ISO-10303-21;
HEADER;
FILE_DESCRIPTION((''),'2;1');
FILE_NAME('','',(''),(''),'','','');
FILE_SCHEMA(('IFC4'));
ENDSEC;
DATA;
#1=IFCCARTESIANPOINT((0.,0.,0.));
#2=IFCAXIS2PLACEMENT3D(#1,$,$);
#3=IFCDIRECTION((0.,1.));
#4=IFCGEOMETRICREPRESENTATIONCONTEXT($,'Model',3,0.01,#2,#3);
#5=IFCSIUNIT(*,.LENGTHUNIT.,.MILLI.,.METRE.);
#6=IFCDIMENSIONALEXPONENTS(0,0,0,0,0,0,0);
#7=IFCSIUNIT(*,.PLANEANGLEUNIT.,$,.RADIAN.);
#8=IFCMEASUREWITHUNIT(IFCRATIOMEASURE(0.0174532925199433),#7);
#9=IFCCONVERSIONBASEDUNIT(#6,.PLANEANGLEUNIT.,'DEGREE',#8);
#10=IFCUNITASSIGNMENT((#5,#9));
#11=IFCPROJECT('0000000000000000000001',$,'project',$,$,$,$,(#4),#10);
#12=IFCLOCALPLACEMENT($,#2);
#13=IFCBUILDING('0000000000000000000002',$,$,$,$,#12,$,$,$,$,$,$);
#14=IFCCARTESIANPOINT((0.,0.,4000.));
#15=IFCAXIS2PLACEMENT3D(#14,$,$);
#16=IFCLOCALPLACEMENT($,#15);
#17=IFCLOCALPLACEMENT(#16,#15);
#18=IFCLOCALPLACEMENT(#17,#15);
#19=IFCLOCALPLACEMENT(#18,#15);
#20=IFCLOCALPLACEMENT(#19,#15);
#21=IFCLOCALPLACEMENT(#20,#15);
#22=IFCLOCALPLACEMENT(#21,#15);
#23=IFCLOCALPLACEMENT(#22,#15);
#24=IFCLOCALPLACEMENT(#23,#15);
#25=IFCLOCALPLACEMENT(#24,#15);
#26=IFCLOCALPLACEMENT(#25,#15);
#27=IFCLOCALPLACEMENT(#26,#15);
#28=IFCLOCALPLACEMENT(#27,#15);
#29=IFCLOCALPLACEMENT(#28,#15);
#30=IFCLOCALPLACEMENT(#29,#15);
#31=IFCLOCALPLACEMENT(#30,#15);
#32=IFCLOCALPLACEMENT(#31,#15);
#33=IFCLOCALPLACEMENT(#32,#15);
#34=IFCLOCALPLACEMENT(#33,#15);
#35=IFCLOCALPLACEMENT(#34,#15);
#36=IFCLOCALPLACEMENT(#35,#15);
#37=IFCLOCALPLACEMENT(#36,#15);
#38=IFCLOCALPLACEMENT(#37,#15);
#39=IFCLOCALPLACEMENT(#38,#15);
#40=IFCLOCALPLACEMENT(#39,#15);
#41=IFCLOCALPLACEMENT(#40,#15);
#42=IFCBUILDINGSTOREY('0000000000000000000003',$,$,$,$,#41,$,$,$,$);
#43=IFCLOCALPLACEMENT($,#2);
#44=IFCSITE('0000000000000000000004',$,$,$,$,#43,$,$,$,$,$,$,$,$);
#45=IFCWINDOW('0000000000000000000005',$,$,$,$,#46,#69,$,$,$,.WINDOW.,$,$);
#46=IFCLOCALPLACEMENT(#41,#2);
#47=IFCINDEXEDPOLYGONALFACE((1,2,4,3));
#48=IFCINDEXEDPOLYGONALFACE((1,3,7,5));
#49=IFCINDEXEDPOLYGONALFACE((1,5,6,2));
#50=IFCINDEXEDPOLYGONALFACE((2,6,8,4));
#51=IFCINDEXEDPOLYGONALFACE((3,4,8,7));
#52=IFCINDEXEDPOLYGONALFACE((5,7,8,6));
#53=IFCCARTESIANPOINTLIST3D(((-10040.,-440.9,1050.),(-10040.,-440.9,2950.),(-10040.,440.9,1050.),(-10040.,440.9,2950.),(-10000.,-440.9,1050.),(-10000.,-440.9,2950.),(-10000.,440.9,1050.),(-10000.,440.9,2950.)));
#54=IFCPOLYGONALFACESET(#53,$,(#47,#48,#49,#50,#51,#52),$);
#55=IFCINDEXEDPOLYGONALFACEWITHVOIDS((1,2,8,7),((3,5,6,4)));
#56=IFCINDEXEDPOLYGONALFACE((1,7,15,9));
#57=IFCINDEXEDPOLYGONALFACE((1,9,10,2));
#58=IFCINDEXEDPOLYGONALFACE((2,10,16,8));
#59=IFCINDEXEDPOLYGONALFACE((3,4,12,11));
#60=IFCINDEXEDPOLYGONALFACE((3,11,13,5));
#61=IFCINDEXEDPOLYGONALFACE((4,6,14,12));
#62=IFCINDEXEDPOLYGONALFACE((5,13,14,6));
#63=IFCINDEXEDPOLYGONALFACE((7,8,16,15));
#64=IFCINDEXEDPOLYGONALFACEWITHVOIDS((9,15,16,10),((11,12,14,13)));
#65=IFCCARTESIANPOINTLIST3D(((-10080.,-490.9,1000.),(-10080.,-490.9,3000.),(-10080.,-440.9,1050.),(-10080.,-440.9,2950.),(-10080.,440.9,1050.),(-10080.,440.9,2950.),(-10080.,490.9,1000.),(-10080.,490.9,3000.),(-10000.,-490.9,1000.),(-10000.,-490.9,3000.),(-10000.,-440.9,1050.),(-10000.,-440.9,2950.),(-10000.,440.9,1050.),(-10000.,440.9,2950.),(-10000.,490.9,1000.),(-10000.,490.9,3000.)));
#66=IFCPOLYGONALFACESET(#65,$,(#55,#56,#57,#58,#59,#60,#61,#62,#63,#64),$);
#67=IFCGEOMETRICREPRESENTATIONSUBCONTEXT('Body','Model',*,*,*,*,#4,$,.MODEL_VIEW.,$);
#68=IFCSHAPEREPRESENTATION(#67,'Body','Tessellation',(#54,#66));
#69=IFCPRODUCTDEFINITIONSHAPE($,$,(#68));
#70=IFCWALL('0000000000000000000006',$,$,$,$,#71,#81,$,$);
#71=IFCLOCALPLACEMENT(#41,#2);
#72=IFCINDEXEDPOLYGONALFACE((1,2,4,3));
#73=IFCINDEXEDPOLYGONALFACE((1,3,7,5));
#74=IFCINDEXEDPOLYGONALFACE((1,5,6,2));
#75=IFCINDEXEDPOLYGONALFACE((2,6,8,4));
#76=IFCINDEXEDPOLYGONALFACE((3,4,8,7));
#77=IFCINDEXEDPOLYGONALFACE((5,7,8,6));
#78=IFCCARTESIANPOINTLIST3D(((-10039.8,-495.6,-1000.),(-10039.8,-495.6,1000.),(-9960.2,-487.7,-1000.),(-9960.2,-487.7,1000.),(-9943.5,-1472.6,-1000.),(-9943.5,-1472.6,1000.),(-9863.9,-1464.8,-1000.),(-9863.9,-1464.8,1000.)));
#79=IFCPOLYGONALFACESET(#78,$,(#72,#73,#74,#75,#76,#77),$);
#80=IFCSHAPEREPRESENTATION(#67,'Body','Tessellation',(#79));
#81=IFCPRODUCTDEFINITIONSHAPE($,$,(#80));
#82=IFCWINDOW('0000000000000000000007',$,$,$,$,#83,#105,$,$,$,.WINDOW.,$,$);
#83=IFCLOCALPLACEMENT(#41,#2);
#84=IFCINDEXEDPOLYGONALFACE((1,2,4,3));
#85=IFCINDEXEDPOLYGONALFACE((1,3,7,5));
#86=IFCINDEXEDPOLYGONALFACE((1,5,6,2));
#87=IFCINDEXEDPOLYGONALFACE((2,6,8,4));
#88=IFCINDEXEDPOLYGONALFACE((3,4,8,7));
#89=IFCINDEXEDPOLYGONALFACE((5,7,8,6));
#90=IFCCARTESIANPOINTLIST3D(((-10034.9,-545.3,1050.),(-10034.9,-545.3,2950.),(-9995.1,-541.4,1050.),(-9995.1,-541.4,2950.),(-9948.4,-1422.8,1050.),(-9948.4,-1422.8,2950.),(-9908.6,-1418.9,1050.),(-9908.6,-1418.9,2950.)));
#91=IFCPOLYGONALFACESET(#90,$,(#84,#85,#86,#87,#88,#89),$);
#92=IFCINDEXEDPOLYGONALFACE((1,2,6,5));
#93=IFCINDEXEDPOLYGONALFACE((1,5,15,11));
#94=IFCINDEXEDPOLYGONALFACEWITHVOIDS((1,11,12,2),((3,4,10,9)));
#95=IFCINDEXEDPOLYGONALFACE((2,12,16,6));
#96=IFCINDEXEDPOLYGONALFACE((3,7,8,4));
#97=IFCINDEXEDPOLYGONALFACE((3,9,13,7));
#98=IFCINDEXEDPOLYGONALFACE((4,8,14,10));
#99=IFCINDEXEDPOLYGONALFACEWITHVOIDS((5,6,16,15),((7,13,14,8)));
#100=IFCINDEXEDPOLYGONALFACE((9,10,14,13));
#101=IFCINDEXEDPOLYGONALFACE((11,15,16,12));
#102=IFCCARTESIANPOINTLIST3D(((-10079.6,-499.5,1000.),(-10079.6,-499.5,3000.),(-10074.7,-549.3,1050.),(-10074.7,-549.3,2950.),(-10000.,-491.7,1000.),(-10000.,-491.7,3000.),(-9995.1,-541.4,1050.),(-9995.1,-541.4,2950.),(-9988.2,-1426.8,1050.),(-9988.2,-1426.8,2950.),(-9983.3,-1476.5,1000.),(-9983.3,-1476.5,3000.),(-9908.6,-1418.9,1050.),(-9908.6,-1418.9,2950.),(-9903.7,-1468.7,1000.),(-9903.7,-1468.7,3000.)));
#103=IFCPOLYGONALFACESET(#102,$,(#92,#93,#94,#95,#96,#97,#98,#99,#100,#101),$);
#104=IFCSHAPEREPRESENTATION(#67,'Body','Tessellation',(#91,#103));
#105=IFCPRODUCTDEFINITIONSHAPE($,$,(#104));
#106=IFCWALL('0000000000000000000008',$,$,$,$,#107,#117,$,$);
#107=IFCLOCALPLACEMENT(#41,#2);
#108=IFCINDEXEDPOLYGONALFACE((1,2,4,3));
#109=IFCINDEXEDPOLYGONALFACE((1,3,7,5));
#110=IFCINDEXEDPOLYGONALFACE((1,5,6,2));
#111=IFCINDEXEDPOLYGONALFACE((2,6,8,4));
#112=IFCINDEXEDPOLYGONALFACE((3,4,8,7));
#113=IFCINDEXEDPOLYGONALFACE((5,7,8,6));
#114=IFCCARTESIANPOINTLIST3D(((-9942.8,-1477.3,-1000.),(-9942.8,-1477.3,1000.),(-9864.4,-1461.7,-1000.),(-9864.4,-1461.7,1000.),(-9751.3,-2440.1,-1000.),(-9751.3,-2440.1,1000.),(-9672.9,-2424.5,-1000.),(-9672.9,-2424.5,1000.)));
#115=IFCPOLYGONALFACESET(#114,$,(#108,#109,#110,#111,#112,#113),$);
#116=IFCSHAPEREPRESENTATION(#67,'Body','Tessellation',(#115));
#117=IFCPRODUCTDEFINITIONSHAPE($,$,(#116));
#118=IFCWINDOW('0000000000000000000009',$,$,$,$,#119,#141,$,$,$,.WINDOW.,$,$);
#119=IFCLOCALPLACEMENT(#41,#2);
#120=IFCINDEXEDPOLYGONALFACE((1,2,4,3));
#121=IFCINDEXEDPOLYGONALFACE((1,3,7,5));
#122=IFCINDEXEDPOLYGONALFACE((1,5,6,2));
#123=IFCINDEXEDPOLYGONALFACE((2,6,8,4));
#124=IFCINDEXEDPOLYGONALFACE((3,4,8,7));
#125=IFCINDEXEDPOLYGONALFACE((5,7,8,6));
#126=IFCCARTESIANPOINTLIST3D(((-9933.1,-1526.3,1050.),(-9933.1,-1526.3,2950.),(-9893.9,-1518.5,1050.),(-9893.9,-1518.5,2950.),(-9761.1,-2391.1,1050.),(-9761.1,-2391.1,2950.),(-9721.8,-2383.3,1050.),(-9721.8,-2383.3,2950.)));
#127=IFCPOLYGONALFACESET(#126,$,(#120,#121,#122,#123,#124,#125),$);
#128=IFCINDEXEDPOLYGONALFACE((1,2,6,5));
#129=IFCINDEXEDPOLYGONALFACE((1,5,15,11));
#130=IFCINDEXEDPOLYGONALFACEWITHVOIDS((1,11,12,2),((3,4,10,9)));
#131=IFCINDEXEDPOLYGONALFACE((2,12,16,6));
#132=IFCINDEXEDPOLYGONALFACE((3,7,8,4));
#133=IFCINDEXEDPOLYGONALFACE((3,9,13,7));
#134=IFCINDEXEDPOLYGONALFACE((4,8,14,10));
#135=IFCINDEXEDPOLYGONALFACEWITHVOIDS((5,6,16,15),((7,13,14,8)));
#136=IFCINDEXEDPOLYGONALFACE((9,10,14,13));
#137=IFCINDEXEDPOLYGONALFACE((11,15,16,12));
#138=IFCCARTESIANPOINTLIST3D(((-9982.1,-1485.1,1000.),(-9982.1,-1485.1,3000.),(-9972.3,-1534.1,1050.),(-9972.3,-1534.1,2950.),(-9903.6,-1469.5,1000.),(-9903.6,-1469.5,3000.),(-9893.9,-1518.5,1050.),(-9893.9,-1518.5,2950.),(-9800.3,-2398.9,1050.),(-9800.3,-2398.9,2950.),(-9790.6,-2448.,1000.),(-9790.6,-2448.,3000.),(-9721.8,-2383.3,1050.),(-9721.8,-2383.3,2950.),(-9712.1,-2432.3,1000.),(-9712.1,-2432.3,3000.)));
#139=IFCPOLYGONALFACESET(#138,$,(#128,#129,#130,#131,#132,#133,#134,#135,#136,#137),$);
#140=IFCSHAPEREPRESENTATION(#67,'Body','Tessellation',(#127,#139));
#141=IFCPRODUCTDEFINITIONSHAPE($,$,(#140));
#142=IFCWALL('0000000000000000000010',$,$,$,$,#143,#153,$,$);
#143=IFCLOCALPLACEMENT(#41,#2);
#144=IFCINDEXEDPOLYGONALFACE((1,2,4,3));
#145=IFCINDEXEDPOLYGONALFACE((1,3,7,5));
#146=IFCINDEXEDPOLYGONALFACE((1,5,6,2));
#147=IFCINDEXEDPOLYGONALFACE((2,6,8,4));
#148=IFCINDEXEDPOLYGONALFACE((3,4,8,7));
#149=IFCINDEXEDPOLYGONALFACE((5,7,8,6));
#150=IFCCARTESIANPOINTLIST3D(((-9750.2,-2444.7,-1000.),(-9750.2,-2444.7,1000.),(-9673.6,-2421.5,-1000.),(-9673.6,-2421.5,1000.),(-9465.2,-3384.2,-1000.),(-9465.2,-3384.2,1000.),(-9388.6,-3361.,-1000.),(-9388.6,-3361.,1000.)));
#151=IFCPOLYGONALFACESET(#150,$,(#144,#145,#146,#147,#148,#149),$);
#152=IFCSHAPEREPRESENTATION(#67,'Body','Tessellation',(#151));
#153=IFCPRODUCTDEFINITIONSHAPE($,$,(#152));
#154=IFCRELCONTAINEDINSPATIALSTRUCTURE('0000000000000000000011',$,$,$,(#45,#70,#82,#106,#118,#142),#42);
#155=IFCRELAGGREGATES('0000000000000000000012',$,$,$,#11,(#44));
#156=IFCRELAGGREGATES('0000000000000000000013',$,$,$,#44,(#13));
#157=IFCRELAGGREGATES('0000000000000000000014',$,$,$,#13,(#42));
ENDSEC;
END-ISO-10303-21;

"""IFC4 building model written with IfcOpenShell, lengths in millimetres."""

from ifc_helpers import new_model, entity, si_unit, converted_unit, direction, frame, origin, origin_2d, place, context, subcontext, project, spatial, rectangle, extrude, element, save


model = new_model("IFC4")

# Units and contexts
model_context = context("Model", 3, precision=0.01, world=origin(), true_north=direction((0.0, 1.0)))
body_context = subcontext(model_context, "Body", "Model", "MODEL_VIEW")
ifc_project = project(units=[si_unit("LENGTHUNIT", "METRE", prefix="MILLI"), converted_unit("PLANEANGLEUNIT", "DEGREE", entity("IfcRatioMeasure", 0.0174532925199433), si_unit("PLANEANGLEUNIT", "RADIAN"), dimensions=[0, 0, 0, 0, 0, 0, 0])], contexts=[model_context])

# Site, building, storey
site_placement = place(None, origin())
site = spatial("IfcSite", under=ifc_project, at=site_placement)
building_placement = place(None, origin())
building = spatial("IfcBuilding", under=site, at=building_placement)
placement_1 = place(None, frame((0.0, 0.0, 4000.0)))
placement_2 = place(placement_1, frame((0.0, 0.0, 4000.0)))
placement_3 = place(placement_2, frame((0.0, 0.0, 4000.0)))
placement_4 = place(placement_3, frame((0.0, 0.0, 4000.0)))
placement_5 = place(placement_4, frame((0.0, 0.0, 4000.0)))
placement_6 = place(placement_5, frame((0.0, 0.0, 4000.0)))
placement_7 = place(placement_6, frame((0.0, 0.0, 4000.0)))
placement_8 = place(placement_7, frame((0.0, 0.0, 4000.0)))
placement_9 = place(placement_8, frame((0.0, 0.0, 4000.0)))
placement_10 = place(placement_9, frame((0.0, 0.0, 4000.0)))
placement_11 = place(placement_10, frame((0.0, 0.0, 4000.0)))
placement_12 = place(placement_11, frame((0.0, 0.0, 4000.0)))
placement_13 = place(placement_12, frame((0.0, 0.0, 4000.0)))
placement_14 = place(placement_13, frame((0.0, 0.0, 4000.0)))
placement_15 = place(placement_14, frame((0.0, 0.0, 4000.0)))
placement_16 = place(placement_15, frame((0.0, 0.0, 4000.0)))
placement_17 = place(placement_16, frame((0.0, 0.0, 4000.0)))
placement_18 = place(placement_17, frame((0.0, 0.0, 4000.0)))
placement_19 = place(placement_18, frame((0.0, 0.0, 4000.0)))
placement_20 = place(placement_19, frame((0.0, 0.0, 4000.0)))
placement_21 = place(placement_20, frame((0.0, 0.0, 4000.0)))
placement_22 = place(placement_21, frame((0.0, 0.0, 4000.0)))
placement_23 = place(placement_22, frame((0.0, 0.0, 4000.0)))
placement_24 = place(placement_23, frame((0.0, 0.0, 4000.0)))
placement_25 = place(placement_24, frame((0.0, 0.0, 4000.0)))
storey_placement = place(placement_25, frame((0.0, 0.0, 4000.0)))
storey = spatial("IfcBuildingStorey", under=building, at=storey_placement)

# Window
cartesian_point_1 = entity("IfcCartesianPoint", [-440.9, -950.0])
shared_polyline = entity("IfcPolyline", [cartesian_point_1, entity("IfcCartesianPoint", [-440.9, 950.0]), entity("IfcCartesianPoint", [-440.9, 950.0]), entity("IfcCartesianPoint", [440.9, 950.0]), entity("IfcCartesianPoint", [440.9, 950.0]), entity("IfcCartesianPoint", [440.9, -950.0]), entity("IfcCartesianPoint", [440.9, -950.0]), entity("IfcCartesianPoint", [-440.9, -950.0]), cartesian_point_1])
window_1_placement = place(storey_placement, frame((-10000.0, 0.0, 2000.0), z_axis=(0.0, 0.0, 1.0), x_axis=(0.000874, -10000.0, 0.0)))
cartesian_point_2 = entity("IfcCartesianPoint", [-490.9, -1000.0])
element("IfcWindow", 1, at=window_1_placement, inside=storey, PredefinedType="WINDOW", context=body_context, shape_type="SweptSolid", body=[
    entity("IfcExtrudedAreaSolid", entity("IfcArbitraryClosedProfileDef", "AREA", None, shared_polyline), entity("IfcAxis2Placement3D", entity("IfcCartesianPoint", [0.0, 0.0, 0.0]), entity("IfcDirection", [0.0, -1.0, 0.0]), entity("IfcDirection", [1.0, 0.0, 0.0])), entity("IfcDirection", [0.0, 0.0, 1.0]), 40.0),
    entity("IfcExtrudedAreaSolid", entity("IfcArbitraryProfileDefWithVoids", "AREA", None, entity("IfcPolyline", [cartesian_point_2, entity("IfcCartesianPoint", [-490.9, 1000.0]), entity("IfcCartesianPoint", [-490.9, 1000.0]), entity("IfcCartesianPoint", [490.9, 1000.0]), entity("IfcCartesianPoint", [490.9, 1000.0]), entity("IfcCartesianPoint", [490.9, -1000.0]), entity("IfcCartesianPoint", [490.9, -1000.0]), entity("IfcCartesianPoint", [-490.9, -1000.0]), cartesian_point_2]), [shared_polyline]), entity("IfcAxis2Placement3D", entity("IfcCartesianPoint", [0.0, 0.0, 0.0]), entity("IfcDirection", [0.0, -1.0, 0.0]), entity("IfcDirection", [1.0, 0.0, 0.0])), entity("IfcDirection", [0.0, 0.0, 1.0]), 80.0),
])

# Wall
wall_1_placement = place(storey_placement, frame((-9951.8, -980.2, -1000.0), z_axis=(0.0, 0.0, 1.0), x_axis=(980.170299, -9951.847376, 0.0)))
element("IfcWall", 2, at=wall_1_placement, inside=storey, context=body_context, shape_type="SweptSolid", body=[
    extrude(rectangle(XDim=981.7, YDim=80.0, at=origin_2d()), origin(), (0.0, 0.0, 1.0), 2000.0),
])

# Window
window_2_placement = place(storey_placement, frame((-9951.8, -980.2, 2000.0), z_axis=(0.0, 0.0, 1.0), x_axis=(980.170299, -9951.847376, 0.0)))
cartesian_point_3 = entity("IfcCartesianPoint", [-490.9, -1000.0])
element("IfcWindow", 3, at=window_2_placement, inside=storey, PredefinedType="WINDOW", context=body_context, shape_type="SweptSolid", body=[
    entity("IfcExtrudedAreaSolid", entity("IfcArbitraryClosedProfileDef", "AREA", None, shared_polyline), entity("IfcAxis2Placement3D", entity("IfcCartesianPoint", [0.0, 0.0, 0.0]), entity("IfcDirection", [0.0, -1.0, 0.0]), entity("IfcDirection", [1.0, 0.0, 0.0])), entity("IfcDirection", [0.0, 0.0, 1.0]), 40.0),
    entity("IfcExtrudedAreaSolid", entity("IfcArbitraryProfileDefWithVoids", "AREA", None, entity("IfcPolyline", [cartesian_point_3, entity("IfcCartesianPoint", [-490.9, 1000.0]), entity("IfcCartesianPoint", [-490.9, 1000.0]), entity("IfcCartesianPoint", [490.9, 1000.0]), entity("IfcCartesianPoint", [490.9, 1000.0]), entity("IfcCartesianPoint", [490.9, -1000.0]), entity("IfcCartesianPoint", [490.9, -1000.0]), entity("IfcCartesianPoint", [-490.9, -1000.0]), cartesian_point_3]), [shared_polyline]), entity("IfcAxis2Placement3D", entity("IfcCartesianPoint", [0.0, 0.0, 0.0]), entity("IfcDirection", [0.0, -1.0, 0.0]), entity("IfcDirection", [1.0, 0.0, 0.0])), entity("IfcDirection", [0.0, 0.0, 1.0]), 80.0),
])

# Wall
wall_2_placement = place(storey_placement, frame((-9807.9, -1950.9, -1000.0), z_axis=(0.0, 0.0, 1.0), x_axis=(1950.902524, -9807.852943, 0.0)))
element("IfcWall", 4, at=wall_2_placement, inside=storey, context=body_context, shape_type="SweptSolid", body=[
    extrude(rectangle(XDim=981.7, YDim=80.0, at=origin_2d()), origin(), (0.0, 0.0, 1.0), 2000.0),
])

# Window
window_3_placement = place(storey_placement, frame((-9807.9, -1950.9, 2000.0), z_axis=(0.0, 0.0, 1.0), x_axis=(1950.902524, -9807.852943, 0.0)))
cartesian_point_4 = entity("IfcCartesianPoint", [-490.9, -1000.0])
element("IfcWindow", 5, at=window_3_placement, inside=storey, PredefinedType="WINDOW", context=body_context, shape_type="SweptSolid", body=[
    entity("IfcExtrudedAreaSolid", entity("IfcArbitraryClosedProfileDef", "AREA", None, shared_polyline), entity("IfcAxis2Placement3D", entity("IfcCartesianPoint", [0.0, 0.0, 0.0]), entity("IfcDirection", [0.0, -1.0, 0.0]), entity("IfcDirection", [1.0, 0.0, 0.0])), entity("IfcDirection", [0.0, 0.0, 1.0]), 40.0),
    entity("IfcExtrudedAreaSolid", entity("IfcArbitraryProfileDefWithVoids", "AREA", None, entity("IfcPolyline", [cartesian_point_4, entity("IfcCartesianPoint", [-490.9, 1000.0]), entity("IfcCartesianPoint", [-490.9, 1000.0]), entity("IfcCartesianPoint", [490.9, 1000.0]), entity("IfcCartesianPoint", [490.9, 1000.0]), entity("IfcCartesianPoint", [490.9, -1000.0]), entity("IfcCartesianPoint", [490.9, -1000.0]), entity("IfcCartesianPoint", [-490.9, -1000.0]), cartesian_point_4]), [shared_polyline]), entity("IfcAxis2Placement3D", entity("IfcCartesianPoint", [0.0, 0.0, 0.0]), entity("IfcDirection", [0.0, -1.0, 0.0]), entity("IfcDirection", [1.0, 0.0, 0.0])), entity("IfcDirection", [0.0, 0.0, 1.0]), 80.0),
])

# Wall
wall_3_placement = place(storey_placement, frame((-9569.4, -2902.8, -1000.0), z_axis=(0.0, 0.0, 1.0), x_axis=(2902.846475, -9569.403447, 0.0)))
element("IfcWall", 6, at=wall_3_placement, inside=storey, context=body_context, shape_type="SweptSolid", body=[
    extrude(rectangle(XDim=981.7, YDim=80.0, at=origin_2d()), origin(), (0.0, 0.0, 1.0), 2000.0),
])

save(model, "model.ifc")
